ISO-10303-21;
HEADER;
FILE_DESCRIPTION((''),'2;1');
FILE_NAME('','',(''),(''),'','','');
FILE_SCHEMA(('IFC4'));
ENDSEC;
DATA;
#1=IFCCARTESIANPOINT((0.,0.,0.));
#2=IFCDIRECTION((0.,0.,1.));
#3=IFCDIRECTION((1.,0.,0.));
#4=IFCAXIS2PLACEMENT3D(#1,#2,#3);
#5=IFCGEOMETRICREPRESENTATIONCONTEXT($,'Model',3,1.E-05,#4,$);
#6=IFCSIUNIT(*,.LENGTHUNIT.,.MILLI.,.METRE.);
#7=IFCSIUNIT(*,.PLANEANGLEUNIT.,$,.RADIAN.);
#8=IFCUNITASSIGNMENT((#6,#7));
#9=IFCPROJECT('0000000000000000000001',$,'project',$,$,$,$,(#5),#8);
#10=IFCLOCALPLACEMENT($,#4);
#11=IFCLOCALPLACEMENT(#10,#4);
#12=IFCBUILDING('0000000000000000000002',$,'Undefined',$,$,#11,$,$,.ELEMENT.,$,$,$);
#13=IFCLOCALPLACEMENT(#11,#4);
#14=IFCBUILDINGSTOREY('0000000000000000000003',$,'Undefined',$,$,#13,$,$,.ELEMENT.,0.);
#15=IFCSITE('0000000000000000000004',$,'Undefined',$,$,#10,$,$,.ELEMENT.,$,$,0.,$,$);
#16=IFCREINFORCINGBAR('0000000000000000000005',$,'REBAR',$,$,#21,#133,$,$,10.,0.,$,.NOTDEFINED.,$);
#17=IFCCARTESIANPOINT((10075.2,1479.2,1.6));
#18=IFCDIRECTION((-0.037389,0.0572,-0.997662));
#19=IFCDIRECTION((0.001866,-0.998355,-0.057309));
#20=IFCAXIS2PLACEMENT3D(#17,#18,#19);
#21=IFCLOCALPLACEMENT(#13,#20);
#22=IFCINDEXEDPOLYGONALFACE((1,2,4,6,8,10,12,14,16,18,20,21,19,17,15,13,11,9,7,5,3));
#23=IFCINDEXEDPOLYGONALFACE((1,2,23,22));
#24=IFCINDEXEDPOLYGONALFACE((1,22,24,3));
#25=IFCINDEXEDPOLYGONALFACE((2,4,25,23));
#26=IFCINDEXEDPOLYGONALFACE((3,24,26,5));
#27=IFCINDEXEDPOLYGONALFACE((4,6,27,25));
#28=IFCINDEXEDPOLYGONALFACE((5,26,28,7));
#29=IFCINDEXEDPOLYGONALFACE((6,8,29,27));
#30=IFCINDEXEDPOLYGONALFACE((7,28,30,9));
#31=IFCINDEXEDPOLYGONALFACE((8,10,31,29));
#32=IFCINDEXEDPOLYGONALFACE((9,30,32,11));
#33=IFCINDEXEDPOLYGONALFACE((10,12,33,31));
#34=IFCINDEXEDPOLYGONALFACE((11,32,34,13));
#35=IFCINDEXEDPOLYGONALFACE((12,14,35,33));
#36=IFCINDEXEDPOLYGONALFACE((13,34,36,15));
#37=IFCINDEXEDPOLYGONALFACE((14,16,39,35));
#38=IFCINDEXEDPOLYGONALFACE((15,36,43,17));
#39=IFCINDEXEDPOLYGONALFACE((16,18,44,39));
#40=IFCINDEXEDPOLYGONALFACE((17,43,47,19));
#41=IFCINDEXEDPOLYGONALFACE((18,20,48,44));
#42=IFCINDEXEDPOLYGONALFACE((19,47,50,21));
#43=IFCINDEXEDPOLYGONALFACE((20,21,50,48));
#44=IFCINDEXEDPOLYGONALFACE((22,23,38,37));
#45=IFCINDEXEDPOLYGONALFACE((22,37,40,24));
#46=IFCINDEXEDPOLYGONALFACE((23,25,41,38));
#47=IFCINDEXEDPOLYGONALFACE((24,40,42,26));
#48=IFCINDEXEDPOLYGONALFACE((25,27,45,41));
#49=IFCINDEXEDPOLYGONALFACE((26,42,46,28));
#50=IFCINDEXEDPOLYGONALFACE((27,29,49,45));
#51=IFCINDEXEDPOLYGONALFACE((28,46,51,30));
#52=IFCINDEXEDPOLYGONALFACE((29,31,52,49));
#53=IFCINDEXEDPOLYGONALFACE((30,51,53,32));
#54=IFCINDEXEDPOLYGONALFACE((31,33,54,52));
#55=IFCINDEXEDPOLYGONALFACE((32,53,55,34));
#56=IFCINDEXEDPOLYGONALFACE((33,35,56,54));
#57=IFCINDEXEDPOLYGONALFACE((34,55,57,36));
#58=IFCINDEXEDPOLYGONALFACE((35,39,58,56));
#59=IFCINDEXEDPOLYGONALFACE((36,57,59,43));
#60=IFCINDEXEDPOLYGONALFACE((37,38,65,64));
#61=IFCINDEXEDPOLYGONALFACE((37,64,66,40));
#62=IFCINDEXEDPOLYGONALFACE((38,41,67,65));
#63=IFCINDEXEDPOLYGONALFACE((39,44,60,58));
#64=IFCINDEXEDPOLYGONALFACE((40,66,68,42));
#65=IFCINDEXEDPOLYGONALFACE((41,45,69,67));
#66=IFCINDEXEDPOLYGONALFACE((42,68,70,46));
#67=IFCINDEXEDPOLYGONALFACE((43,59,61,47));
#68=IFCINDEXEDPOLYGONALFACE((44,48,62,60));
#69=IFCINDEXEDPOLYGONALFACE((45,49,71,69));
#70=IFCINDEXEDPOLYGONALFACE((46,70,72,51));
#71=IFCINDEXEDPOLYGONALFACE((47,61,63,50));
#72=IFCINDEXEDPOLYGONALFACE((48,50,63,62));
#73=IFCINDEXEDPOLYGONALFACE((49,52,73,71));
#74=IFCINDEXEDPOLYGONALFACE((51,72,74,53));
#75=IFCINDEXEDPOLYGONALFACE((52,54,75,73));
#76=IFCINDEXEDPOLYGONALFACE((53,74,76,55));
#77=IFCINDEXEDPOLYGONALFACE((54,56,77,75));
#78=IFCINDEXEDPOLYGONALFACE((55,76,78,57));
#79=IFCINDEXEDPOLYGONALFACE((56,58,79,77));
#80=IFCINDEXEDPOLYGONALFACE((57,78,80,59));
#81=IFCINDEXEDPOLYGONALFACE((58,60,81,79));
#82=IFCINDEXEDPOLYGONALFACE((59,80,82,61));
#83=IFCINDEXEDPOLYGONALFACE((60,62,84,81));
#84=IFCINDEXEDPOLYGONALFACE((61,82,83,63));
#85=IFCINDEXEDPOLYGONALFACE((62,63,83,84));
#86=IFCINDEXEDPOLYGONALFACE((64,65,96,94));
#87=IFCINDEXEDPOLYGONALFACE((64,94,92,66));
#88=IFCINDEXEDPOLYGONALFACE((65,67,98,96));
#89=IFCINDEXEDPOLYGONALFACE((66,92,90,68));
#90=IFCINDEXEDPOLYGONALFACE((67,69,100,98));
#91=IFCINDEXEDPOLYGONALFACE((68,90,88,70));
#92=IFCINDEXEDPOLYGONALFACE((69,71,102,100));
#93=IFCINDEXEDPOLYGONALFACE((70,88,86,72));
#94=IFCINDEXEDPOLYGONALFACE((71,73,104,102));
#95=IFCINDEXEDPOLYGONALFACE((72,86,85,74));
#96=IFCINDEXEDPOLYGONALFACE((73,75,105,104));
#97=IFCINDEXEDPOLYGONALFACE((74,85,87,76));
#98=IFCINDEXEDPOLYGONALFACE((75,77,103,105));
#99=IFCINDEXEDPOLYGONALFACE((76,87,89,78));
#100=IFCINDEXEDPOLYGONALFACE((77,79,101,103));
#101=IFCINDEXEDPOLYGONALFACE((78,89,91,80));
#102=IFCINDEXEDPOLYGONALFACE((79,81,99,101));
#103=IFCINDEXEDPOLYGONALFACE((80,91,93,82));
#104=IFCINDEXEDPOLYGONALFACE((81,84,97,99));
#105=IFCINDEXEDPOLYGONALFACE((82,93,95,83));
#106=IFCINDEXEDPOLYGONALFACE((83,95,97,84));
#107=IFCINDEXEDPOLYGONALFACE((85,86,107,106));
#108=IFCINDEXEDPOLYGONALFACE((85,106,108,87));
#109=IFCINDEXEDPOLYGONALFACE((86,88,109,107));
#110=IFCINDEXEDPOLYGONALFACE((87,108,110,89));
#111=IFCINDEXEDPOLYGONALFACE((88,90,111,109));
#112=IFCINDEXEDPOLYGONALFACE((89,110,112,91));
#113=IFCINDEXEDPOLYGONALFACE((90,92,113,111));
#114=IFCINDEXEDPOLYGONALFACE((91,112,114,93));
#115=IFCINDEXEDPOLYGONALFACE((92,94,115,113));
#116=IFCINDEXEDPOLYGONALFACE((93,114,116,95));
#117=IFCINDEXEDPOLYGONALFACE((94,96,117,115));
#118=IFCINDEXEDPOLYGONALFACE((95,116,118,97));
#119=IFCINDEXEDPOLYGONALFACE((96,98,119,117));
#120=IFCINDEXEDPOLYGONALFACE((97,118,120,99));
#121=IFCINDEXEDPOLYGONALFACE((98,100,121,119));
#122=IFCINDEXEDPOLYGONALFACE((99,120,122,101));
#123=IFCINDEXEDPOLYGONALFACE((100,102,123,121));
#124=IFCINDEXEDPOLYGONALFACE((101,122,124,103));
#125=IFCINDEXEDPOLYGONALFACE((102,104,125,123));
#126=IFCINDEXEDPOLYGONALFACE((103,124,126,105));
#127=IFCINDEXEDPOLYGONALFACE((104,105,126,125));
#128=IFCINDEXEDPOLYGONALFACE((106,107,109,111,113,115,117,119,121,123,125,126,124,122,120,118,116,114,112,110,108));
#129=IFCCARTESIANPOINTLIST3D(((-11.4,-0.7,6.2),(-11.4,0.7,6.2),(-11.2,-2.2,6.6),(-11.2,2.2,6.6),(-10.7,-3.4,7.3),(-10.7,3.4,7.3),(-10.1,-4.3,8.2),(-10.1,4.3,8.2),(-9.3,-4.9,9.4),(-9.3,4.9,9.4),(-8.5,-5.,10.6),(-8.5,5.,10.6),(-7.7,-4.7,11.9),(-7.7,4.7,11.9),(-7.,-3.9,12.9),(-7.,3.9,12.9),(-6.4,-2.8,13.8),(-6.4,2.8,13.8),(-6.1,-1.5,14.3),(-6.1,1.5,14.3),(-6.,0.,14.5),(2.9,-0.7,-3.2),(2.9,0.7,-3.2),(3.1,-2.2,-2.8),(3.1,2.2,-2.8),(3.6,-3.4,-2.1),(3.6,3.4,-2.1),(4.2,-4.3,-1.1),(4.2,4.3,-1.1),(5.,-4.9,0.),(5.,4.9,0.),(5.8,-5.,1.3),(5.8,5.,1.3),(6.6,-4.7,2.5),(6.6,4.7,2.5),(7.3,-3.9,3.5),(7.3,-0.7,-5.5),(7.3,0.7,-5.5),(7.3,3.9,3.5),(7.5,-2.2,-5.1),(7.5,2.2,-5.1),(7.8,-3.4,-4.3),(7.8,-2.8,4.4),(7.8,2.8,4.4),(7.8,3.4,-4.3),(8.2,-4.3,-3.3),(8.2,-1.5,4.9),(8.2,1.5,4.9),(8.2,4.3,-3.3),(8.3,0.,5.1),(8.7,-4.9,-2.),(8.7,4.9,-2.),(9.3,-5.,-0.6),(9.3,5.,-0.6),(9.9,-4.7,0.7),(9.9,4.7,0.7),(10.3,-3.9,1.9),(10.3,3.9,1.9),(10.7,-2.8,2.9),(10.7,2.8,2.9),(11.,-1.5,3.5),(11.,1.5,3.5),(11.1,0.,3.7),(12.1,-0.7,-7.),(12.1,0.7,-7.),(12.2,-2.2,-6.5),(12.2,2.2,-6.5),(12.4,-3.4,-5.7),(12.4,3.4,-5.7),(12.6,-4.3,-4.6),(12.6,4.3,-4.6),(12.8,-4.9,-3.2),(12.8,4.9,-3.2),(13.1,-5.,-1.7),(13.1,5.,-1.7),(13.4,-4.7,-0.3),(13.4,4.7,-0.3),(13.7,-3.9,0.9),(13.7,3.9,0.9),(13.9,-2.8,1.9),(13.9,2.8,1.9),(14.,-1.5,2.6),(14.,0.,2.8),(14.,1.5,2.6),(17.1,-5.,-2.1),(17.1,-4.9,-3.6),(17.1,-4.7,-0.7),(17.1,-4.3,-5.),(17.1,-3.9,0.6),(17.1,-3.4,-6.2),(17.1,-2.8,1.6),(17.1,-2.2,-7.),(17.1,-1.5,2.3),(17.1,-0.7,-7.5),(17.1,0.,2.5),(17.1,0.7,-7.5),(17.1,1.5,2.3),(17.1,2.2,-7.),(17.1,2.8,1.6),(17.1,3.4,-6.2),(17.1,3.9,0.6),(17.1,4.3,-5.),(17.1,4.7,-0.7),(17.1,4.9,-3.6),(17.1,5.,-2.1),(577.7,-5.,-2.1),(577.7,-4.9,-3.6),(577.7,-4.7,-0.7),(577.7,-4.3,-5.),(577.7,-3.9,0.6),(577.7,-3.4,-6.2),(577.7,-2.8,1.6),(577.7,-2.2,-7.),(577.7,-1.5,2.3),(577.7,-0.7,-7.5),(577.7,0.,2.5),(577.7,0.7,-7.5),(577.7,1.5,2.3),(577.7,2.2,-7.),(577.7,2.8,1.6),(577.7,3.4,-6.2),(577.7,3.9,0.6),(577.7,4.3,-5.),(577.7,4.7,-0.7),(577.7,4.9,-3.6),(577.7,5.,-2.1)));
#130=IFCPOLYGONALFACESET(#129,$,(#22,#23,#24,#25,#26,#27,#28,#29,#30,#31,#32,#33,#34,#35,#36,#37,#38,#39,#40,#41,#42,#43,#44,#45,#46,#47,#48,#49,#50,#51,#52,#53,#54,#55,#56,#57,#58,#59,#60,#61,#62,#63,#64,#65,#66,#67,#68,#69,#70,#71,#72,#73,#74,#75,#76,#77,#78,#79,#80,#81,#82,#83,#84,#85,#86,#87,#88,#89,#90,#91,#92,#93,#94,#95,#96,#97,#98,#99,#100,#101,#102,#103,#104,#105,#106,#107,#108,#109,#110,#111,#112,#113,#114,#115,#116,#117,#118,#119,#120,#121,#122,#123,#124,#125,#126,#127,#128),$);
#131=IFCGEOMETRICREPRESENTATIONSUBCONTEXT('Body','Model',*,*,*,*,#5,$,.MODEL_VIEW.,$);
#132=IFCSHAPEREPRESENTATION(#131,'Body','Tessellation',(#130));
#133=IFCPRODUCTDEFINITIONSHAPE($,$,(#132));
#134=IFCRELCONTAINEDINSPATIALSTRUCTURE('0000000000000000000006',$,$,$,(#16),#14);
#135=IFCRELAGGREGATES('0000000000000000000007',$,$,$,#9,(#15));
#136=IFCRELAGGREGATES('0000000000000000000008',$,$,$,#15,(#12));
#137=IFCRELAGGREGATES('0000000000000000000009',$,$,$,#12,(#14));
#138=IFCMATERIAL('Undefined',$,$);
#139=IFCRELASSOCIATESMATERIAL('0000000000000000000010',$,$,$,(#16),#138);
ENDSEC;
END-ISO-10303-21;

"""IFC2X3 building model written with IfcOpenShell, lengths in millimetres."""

from ifc_helpers import new_model, entity, si_unit, frame, origin_with_axes, place, context, subcontext, project, spatial, source, transform, mapped, material, element, save


model = new_model("IFC2X3")

# Units and contexts
model_context = context("Model", 3, precision=1e-05, world=origin_with_axes())
body_context = subcontext(model_context, "Body", "Model", "MODEL_VIEW")
ifc_project = project(units=[si_unit("LENGTHUNIT", "METRE", prefix="MILLI"), si_unit("PLANEANGLEUNIT", "RADIAN")], contexts=[model_context])

# Site, building, storey
site_placement = place(None, origin_with_axes())
site = spatial("IfcSite", under=ifc_project, at=site_placement, Name="Undefined", CompositionType="ELEMENT", RefElevation=0.0)
building_placement = place(site_placement, origin_with_axes())
building = spatial("IfcBuilding", under=site, at=building_placement, Name="Undefined", CompositionType="ELEMENT")
storey_placement = place(building_placement, origin_with_axes())
storey = spatial("IfcBuildingStorey", under=building, at=storey_placement, Name="Undefined", CompositionType="ELEMENT", Elevation=0.0)

# Reinforcing bar
ifc_material_1 = material(Name="Undefined")
shared_shape_1 = source(origin_with_axes(), body_context, "Body", "AdvancedSweptSolid", [
    entity("IfcSweptDiskSolid", entity("IfcCompositeCurve", [entity("IfcCompositeCurveSegment", "CONTINUOUS", True, entity("IfcTrimmedCurve", entity("IfcLine", entity("IfcCartesianPoint", [0.0, 0.0, 0.0]), entity("IfcVector", entity("IfcDirection", [0.835483, 0.0, -0.549516]), 1.0)), [entity("IfcParameterValue", 0.0)], [entity("IfcParameterValue", 17.082101)], True, "PARAMETER")), entity("IfcCompositeCurveSegment", "CONTINUOUS", True, entity("IfcTrimmedCurve", entity("IfcCircle", entity("IfcAxis2Placement3D", entity("IfcCartesianPoint", [25.8, 0.0, 8.2]), entity("IfcDirection", [0.0, -1.0, 0.0]), entity("IfcDirection", [-0.549516, 0.0, -0.835483])), 21.0), [entity("IfcParameterValue", 0.0)], [entity("IfcParameterValue", 0.581785)], True, "PARAMETER")), entity("IfcCompositeCurveSegment", "DISCONTINUOUS", True, entity("IfcTrimmedCurve", entity("IfcLine", entity("IfcCartesianPoint", [25.8, 0.0, -12.8]), entity("IfcVector", entity("IfcDirection", [1.0, 0.0, 0.0]), 1.0)), [entity("IfcParameterValue", 0.0)], [entity("IfcParameterValue", 560.593055)], True, "PARAMETER"))], False), 5.0, None, 0.0, 578.3),
])
reinforcing_bar_1_placement = place(storey_placement, frame((10075.2, 1479.2, 1.6), z_axis=(-0.037389, 0.0572, -0.997662), x_axis=(0.001866, -0.998355, -0.057309)))
element("IfcReinforcingBar", 1, at=reinforcing_bar_1_placement, inside=storey, material=ifc_material_1, Name="REBAR", BarRole="NOTDEFINED", CrossSectionArea=0.0, NominalDiameter=10.0, context=body_context, shape_type="MappedRepresentation", body=[
    mapped(shared_shape_1, transform((-8.7, 0.0, 10.3))),
])

save(model, "model.ifc")
